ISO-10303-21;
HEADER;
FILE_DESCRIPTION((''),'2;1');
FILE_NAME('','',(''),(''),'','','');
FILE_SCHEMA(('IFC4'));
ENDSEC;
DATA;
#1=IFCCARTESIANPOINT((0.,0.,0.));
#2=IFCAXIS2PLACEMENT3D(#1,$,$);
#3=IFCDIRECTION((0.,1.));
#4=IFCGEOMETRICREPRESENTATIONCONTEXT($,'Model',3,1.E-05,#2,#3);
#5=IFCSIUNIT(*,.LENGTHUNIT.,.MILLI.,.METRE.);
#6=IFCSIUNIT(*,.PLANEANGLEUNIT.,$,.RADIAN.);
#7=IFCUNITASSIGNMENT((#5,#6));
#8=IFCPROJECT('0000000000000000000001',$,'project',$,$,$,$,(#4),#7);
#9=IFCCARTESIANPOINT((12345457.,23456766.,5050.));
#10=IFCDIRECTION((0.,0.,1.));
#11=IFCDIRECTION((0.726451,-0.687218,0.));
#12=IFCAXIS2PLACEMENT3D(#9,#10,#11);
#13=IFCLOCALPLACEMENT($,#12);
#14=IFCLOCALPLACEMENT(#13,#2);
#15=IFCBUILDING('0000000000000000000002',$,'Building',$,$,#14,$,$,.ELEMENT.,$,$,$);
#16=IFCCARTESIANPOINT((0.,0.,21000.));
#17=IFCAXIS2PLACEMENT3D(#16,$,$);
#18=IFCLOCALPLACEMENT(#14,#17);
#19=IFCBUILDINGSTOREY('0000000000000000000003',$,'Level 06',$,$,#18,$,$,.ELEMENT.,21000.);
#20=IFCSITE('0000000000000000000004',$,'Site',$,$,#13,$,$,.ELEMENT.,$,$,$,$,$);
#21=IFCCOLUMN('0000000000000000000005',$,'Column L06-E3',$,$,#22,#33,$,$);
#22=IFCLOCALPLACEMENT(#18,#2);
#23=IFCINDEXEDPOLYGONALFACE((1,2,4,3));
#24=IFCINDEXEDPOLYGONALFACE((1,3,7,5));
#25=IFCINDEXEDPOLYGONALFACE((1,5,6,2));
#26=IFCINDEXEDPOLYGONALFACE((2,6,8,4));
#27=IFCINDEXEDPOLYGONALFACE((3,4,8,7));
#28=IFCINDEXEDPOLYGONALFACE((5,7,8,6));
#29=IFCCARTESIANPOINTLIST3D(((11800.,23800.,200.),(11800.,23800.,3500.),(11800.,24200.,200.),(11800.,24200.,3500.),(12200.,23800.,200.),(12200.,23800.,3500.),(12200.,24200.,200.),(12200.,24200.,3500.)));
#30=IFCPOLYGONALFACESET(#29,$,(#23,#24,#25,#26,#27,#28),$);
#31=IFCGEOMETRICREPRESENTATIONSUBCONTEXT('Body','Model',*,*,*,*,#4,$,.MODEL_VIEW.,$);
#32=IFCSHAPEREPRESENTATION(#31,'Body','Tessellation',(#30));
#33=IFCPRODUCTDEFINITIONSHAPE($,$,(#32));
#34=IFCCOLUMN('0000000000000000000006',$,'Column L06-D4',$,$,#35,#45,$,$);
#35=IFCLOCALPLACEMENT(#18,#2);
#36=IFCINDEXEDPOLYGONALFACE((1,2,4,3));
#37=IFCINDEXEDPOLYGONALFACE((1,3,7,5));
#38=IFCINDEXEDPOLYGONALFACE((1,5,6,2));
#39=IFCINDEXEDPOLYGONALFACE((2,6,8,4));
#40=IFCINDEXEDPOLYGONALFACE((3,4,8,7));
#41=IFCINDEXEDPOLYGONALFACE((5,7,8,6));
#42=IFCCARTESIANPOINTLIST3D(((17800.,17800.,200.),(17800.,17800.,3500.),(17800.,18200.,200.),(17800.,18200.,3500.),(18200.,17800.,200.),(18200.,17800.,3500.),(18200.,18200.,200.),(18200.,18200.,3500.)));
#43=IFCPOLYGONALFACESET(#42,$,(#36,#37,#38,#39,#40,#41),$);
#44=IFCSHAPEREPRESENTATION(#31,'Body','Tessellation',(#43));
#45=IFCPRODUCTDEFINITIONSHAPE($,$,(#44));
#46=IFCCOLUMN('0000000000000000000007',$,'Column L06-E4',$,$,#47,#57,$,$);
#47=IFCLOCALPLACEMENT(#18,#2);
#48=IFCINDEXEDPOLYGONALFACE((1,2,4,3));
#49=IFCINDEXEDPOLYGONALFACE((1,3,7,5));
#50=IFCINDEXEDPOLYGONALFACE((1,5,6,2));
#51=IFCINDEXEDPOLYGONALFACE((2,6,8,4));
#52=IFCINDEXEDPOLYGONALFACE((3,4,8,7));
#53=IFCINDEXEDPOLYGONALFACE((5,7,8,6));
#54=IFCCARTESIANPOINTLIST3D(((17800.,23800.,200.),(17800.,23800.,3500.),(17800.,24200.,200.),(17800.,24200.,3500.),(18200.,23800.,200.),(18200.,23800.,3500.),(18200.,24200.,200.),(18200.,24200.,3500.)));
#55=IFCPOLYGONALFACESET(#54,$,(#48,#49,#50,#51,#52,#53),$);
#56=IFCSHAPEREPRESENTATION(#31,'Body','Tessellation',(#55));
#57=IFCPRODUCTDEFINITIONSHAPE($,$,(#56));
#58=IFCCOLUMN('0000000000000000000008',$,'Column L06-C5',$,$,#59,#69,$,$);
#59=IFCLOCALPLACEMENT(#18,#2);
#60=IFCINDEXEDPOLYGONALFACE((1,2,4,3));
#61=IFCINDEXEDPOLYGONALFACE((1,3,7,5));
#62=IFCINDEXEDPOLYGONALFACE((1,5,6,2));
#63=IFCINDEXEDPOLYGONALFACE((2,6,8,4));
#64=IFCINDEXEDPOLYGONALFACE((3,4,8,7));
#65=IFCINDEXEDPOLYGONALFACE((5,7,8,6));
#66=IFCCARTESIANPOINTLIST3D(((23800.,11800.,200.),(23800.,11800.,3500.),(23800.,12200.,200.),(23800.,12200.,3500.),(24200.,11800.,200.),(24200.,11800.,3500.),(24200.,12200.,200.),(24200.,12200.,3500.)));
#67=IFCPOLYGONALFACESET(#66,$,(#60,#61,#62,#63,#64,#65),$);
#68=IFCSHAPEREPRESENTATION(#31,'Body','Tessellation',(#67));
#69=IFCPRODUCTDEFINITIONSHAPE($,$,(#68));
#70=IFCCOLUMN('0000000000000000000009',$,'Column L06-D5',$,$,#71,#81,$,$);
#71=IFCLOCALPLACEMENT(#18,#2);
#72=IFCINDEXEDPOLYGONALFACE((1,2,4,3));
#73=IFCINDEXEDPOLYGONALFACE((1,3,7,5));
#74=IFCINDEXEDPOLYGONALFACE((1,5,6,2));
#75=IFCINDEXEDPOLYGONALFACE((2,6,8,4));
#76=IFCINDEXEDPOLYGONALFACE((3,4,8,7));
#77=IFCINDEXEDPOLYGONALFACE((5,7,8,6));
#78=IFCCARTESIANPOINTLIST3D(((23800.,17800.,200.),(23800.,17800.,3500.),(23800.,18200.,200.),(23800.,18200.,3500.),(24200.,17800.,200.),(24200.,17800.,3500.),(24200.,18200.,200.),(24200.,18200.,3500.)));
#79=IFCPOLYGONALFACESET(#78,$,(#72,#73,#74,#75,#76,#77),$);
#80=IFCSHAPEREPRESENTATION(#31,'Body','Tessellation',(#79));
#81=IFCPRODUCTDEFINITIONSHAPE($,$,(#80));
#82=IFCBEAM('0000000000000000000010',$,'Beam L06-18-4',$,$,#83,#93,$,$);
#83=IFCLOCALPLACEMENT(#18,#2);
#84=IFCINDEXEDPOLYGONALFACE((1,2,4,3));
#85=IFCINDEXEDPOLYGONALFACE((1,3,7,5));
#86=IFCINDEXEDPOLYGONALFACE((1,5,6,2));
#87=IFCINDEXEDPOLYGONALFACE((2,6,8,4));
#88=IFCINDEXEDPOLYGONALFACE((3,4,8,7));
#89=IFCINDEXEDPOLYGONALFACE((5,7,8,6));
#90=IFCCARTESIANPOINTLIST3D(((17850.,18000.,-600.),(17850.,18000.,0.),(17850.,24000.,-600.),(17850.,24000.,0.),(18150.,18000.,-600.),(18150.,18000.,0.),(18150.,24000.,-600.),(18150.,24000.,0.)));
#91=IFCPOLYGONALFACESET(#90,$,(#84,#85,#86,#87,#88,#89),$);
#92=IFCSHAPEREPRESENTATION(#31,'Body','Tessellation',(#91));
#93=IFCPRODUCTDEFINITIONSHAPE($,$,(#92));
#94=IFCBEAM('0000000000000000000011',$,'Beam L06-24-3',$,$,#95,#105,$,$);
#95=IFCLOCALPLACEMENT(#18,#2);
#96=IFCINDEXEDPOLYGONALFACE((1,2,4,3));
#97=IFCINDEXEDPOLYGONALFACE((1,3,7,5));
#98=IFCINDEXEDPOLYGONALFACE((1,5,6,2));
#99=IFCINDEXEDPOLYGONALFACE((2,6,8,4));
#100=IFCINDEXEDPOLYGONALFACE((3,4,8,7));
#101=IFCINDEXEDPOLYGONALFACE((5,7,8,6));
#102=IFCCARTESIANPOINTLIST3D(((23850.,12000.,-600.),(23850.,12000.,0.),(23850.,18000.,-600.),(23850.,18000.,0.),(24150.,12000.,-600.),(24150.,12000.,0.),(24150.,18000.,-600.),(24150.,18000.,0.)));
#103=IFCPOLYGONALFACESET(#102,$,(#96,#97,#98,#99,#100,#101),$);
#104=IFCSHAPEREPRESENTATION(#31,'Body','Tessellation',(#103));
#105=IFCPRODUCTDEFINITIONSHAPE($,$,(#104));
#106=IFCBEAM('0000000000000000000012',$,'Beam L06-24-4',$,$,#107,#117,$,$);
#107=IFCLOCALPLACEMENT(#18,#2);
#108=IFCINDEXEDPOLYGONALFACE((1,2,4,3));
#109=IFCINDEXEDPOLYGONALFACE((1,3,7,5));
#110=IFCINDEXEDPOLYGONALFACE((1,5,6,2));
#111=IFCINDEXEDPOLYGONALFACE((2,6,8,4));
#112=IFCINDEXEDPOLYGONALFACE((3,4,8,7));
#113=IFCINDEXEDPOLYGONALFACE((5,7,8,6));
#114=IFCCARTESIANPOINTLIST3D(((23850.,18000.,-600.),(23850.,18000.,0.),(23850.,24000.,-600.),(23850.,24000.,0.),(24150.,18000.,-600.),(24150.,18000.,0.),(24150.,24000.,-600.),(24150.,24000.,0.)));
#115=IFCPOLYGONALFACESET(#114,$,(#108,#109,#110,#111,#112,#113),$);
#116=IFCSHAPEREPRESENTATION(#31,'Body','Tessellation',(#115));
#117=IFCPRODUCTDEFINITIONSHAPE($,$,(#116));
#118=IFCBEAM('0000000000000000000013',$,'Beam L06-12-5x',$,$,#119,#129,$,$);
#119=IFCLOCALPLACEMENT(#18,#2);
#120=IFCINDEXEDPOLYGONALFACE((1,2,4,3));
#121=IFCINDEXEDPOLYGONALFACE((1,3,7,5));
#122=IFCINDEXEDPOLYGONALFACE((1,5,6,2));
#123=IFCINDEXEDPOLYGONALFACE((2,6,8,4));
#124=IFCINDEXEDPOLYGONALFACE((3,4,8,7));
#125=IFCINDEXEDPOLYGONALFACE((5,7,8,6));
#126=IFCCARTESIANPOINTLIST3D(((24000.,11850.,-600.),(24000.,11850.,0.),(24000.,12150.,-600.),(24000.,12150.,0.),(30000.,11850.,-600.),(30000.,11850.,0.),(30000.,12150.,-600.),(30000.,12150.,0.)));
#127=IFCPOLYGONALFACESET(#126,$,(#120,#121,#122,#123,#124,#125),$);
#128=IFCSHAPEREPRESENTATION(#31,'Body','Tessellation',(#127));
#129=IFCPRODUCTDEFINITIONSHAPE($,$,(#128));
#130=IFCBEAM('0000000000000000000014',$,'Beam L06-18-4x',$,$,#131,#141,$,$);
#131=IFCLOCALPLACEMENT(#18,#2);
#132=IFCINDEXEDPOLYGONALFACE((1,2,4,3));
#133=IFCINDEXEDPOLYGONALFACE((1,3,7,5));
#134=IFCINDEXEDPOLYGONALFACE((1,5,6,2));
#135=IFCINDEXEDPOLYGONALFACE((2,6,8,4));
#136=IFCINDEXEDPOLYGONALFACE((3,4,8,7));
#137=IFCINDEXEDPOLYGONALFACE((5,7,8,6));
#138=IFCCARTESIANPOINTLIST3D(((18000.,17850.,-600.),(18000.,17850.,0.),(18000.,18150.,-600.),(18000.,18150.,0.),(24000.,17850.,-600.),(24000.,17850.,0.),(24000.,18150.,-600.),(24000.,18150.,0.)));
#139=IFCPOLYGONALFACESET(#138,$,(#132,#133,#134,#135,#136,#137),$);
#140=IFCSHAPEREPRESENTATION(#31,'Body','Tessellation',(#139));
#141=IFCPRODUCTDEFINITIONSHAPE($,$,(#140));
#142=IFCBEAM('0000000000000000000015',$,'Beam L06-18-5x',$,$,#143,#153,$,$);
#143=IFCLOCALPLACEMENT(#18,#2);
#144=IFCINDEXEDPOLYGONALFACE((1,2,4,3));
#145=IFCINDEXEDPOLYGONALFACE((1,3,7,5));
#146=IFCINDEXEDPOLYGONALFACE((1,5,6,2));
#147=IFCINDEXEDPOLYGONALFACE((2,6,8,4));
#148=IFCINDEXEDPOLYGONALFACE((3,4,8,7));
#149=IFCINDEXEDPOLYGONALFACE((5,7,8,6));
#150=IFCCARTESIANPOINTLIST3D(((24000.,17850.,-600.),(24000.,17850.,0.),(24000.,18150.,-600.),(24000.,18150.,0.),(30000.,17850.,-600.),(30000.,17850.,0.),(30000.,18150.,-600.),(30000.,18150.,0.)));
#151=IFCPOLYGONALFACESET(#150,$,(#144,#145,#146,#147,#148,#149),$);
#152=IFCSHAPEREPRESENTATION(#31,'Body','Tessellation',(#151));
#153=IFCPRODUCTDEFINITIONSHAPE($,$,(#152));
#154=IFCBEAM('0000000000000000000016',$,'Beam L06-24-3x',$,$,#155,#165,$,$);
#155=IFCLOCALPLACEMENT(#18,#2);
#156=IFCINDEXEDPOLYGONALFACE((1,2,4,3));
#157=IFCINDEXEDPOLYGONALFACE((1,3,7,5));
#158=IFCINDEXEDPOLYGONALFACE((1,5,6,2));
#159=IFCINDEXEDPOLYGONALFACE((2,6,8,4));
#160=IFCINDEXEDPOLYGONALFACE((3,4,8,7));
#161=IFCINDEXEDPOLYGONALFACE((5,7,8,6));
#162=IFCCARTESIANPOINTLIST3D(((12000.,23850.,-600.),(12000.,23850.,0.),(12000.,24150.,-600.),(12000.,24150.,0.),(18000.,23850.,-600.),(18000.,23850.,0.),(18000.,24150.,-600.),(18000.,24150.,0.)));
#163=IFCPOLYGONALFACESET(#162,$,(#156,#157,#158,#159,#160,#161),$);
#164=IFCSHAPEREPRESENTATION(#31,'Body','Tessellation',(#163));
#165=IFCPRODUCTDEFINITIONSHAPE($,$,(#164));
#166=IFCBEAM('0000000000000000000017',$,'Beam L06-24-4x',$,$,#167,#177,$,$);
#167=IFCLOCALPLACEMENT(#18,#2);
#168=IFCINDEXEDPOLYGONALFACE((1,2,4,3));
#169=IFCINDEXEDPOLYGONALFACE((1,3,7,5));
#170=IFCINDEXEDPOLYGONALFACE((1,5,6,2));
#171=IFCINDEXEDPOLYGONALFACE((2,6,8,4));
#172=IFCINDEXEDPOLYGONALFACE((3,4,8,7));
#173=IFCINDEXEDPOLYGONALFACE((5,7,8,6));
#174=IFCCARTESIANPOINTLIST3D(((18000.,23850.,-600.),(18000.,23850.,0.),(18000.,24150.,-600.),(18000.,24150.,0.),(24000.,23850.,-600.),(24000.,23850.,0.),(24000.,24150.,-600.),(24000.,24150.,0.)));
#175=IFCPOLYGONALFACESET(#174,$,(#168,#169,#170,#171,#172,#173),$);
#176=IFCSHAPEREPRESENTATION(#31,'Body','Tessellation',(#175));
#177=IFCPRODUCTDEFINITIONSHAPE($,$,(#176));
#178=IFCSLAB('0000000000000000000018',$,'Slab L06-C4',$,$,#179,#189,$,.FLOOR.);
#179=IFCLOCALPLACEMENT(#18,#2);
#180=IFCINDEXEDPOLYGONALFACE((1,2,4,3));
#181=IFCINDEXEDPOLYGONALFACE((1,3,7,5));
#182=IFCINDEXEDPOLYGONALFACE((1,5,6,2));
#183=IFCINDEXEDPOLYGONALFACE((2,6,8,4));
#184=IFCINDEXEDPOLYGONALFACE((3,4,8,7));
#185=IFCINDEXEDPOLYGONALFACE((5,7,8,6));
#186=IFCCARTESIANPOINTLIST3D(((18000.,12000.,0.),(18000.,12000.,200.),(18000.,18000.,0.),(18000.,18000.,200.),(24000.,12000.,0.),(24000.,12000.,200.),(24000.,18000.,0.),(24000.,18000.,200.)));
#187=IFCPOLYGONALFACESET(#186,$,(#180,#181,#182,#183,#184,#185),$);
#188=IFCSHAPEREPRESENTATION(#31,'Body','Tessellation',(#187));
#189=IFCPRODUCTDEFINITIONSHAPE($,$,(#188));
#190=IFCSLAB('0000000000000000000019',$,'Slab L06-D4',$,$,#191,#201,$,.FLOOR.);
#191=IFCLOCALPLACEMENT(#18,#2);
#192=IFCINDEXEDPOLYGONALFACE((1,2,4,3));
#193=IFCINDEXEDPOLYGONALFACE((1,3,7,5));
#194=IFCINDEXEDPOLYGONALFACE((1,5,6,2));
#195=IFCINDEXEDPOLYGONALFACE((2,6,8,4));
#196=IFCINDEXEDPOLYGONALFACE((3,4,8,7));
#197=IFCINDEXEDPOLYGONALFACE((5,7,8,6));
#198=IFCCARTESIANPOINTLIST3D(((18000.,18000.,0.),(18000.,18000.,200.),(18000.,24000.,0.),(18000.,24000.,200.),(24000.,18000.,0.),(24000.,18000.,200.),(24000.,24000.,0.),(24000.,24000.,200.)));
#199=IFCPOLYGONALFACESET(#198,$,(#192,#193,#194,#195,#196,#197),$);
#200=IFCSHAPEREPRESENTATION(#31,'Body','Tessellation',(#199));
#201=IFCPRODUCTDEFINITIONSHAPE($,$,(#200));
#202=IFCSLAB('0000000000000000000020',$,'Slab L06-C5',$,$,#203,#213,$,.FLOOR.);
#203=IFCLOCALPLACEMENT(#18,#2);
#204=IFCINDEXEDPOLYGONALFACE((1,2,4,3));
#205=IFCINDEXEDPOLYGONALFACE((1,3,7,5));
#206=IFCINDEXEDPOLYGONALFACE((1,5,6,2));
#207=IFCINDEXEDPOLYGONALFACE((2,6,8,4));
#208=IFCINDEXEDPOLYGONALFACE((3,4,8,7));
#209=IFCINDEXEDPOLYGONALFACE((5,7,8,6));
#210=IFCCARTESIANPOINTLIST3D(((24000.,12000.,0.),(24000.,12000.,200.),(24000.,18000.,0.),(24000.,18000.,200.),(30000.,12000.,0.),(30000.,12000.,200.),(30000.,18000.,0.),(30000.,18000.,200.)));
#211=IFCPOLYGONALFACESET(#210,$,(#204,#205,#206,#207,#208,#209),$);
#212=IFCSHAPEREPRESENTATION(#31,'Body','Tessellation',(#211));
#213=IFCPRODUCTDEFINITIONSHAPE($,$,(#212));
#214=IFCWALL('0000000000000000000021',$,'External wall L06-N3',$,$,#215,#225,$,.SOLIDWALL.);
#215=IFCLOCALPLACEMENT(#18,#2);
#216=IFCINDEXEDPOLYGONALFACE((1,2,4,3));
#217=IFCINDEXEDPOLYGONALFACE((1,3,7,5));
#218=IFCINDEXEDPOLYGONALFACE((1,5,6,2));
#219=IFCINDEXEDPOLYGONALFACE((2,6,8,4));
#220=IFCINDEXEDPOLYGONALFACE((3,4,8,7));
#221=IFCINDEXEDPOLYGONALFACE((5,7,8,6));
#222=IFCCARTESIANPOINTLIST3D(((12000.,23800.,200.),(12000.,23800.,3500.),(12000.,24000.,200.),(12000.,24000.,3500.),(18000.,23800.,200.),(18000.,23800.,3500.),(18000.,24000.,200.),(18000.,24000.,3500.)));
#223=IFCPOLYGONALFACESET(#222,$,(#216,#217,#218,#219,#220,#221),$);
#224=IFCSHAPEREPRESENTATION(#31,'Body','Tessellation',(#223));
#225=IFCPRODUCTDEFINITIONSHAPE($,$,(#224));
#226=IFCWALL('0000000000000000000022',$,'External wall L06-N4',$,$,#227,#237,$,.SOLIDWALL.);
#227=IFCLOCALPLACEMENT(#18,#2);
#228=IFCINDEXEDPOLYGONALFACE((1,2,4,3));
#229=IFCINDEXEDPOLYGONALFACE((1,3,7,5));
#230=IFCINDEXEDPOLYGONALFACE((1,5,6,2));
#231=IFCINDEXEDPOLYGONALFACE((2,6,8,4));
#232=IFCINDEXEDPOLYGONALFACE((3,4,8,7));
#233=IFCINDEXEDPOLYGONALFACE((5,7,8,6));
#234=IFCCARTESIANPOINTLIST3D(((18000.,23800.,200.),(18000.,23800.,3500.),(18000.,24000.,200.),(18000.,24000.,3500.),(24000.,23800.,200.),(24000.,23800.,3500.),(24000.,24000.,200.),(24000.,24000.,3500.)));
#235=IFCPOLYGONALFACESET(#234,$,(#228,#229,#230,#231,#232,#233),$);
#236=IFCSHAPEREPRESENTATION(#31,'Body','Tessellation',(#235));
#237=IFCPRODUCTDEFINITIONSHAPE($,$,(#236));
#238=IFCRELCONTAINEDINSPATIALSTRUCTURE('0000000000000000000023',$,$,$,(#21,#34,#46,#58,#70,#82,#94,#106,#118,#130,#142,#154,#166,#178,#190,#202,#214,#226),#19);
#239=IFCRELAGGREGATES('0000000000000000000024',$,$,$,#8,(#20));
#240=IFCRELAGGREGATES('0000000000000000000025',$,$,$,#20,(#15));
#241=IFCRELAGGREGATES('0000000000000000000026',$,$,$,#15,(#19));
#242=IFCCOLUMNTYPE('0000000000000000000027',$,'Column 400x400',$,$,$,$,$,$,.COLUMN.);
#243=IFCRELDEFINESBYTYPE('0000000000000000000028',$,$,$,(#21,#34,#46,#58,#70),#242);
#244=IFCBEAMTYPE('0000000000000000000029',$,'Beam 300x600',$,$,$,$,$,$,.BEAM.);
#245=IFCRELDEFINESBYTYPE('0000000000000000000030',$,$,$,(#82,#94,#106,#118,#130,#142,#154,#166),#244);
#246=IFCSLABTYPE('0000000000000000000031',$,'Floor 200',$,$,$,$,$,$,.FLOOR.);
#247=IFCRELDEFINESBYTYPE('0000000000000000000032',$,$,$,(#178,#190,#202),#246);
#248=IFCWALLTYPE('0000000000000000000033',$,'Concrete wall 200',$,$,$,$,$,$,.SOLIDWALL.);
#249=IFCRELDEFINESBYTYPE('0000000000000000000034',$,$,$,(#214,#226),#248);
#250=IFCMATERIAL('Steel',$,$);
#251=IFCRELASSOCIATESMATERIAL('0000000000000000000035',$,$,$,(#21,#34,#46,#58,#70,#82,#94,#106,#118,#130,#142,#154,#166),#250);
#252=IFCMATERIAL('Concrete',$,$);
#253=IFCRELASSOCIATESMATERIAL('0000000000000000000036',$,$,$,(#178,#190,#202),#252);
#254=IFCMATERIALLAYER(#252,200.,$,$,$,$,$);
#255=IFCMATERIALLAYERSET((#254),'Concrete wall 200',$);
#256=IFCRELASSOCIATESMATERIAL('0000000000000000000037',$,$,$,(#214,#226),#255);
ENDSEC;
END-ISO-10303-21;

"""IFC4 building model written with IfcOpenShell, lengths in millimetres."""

from ifc_helpers import new_model, si_unit, direction, frame, origin, place, context, subcontext, project, spatial, rectangle, extrude, material, layer, layer_set, layer_usage, type_object, element, save


model = new_model("IFC4")

# Units and contexts
model_context = context("Model", 3, precision=1e-05, world=origin(), true_north=direction((0.0, 1.0)))
body_context = subcontext(model_context, "Body", "Model", "MODEL_VIEW")
ifc_project = project(units=[si_unit("LENGTHUNIT", "METRE", prefix="MILLI"), si_unit("PLANEANGLEUNIT", "RADIAN")], contexts=[model_context])

# Site, building, storey
site_placement = place(None, frame((12345457.0, 23456766.0, 5050.0), z_axis=(0.0, 0.0, 1.0), x_axis=(0.726451, -0.687218, 0.0)))
site = spatial("IfcSite", under=ifc_project, at=site_placement, Name="Site", CompositionType="ELEMENT")
building_placement = place(site_placement, origin())
building = spatial("IfcBuilding", under=site, at=building_placement, Name="Building", CompositionType="ELEMENT")
storey_placement = place(building_placement, frame((0.0, 0.0, 21000.0)))
storey = spatial("IfcBuildingStorey", under=building, at=storey_placement, Name="Level 06", CompositionType="ELEMENT", Elevation=21000.0)

# Columns
ifc_material_1 = material(Name="Steel")
column_type = type_object("IfcColumnType", Name="Column 400x400", PredefinedType="COLUMN")
for number, where, name in (
    (1, (11800.0, 23800.0, 200.0), "Column L06-E3"),
    (2, (17800.0, 17800.0, 200.0), "Column L06-D4"),
    (3, (17800.0, 23800.0, 200.0), "Column L06-E4"),
    (4, (23800.0, 11800.0, 200.0), "Column L06-C5"),
    (5, (23800.0, 17800.0, 200.0), "Column L06-D5"),
):
    element("IfcColumn", number, at=place(storey_placement, frame(where)), inside=storey, type_object=column_type, material=ifc_material_1, Name=name, context=body_context, shape_type="SweptSolid", body=[
        extrude(rectangle(XDim=400.0, YDim=400.0), frame((200.0, 200.0, 0.0)), (0.0, 0.0, 1.0), 3300.0),
    ])

# Beams
beam_type = type_object("IfcBeamType", Name="Beam 300x600", PredefinedType="BEAM")
for number, where, name in (
    (6, (17850.0, 18000.0, -600.0), "Beam L06-18-4"),
    (7, (23850.0, 12000.0, -600.0), "Beam L06-24-3"),
    (8, (23850.0, 18000.0, -600.0), "Beam L06-24-4"),
):
    element("IfcBeam", number, at=place(storey_placement, frame(where)), inside=storey, type_object=beam_type, material=ifc_material_1, Name=name, context=body_context, shape_type="SweptSolid", body=[
        extrude(rectangle(XDim=300.0, YDim=6000.0), frame((150.0, 3000.0, 0.0)), (0.0, 0.0, 1.0), 600.0),
    ])
for number, where, name in (
    (9, (24000.0, 11850.0, -600.0), "Beam L06-12-5x"),
    (10, (18000.0, 17850.0, -600.0), "Beam L06-18-4x"),
    (11, (24000.0, 17850.0, -600.0), "Beam L06-18-5x"),
    (12, (12000.0, 23850.0, -600.0), "Beam L06-24-3x"),
    (13, (18000.0, 23850.0, -600.0), "Beam L06-24-4x"),
):
    element("IfcBeam", number, at=place(storey_placement, frame(where)), inside=storey, type_object=beam_type, material=ifc_material_1, Name=name, context=body_context, shape_type="SweptSolid", body=[
        extrude(rectangle(XDim=6000.0, YDim=300.0), frame((3000.0, 150.0, 0.0)), (0.0, 0.0, 1.0), 600.0),
    ])

# Slabs
ifc_material_2 = material(Name="Concrete")
slab_type = type_object("IfcSlabType", Name="Floor 200", PredefinedType="FLOOR")
for number, where, name in (
    (14, (18000.0, 12000.0, 0.0), "Slab L06-C4"),
    (15, (18000.0, 18000.0, 0.0), "Slab L06-D4"),
    (16, (24000.0, 12000.0, 0.0), "Slab L06-C5"),
):
    element("IfcSlab", number, at=place(storey_placement, frame(where)), inside=storey, type_object=slab_type, material=ifc_material_2, Name=name, PredefinedType="FLOOR", context=body_context, shape_type="SweptSolid", body=[
        extrude(rectangle(XDim=6000.0, YDim=6000.0), frame((3000.0, 3000.0, 0.0)), (0.0, 0.0, 1.0), 200.0),
    ])

# Walls
ifc_layer_1 = layer(ifc_material_2, 200.0)
ifc_layer_set_1 = layer_set([ifc_layer_1], Name="Concrete wall 200")
ifc_layer_usage_1 = layer_usage(ifc_layer_set_1, "AXIS2", "POSITIVE", 0.0)
wall_type_1 = type_object("IfcWallType", Name="Concrete wall 200", PredefinedType="SOLIDWALL")
for number, where, name in (
    (17, (12000.0, 23800.0, 200.0), "External wall L06-N3"),
    (18, (18000.0, 23800.0, 200.0), "External wall L06-N4"),
):
    element("IfcWall", number, at=place(storey_placement, frame(where)), inside=storey, type_object=wall_type_1, material=ifc_layer_usage_1, Name=name, PredefinedType="SOLIDWALL", context=body_context, shape_type="SweptSolid", body=[
        extrude(rectangle(XDim=6000.0, YDim=200.0), frame((3000.0, 100.0, 0.0)), (0.0, 0.0, 1.0), 3300.0),
    ])

save(model, "model.ifc")
